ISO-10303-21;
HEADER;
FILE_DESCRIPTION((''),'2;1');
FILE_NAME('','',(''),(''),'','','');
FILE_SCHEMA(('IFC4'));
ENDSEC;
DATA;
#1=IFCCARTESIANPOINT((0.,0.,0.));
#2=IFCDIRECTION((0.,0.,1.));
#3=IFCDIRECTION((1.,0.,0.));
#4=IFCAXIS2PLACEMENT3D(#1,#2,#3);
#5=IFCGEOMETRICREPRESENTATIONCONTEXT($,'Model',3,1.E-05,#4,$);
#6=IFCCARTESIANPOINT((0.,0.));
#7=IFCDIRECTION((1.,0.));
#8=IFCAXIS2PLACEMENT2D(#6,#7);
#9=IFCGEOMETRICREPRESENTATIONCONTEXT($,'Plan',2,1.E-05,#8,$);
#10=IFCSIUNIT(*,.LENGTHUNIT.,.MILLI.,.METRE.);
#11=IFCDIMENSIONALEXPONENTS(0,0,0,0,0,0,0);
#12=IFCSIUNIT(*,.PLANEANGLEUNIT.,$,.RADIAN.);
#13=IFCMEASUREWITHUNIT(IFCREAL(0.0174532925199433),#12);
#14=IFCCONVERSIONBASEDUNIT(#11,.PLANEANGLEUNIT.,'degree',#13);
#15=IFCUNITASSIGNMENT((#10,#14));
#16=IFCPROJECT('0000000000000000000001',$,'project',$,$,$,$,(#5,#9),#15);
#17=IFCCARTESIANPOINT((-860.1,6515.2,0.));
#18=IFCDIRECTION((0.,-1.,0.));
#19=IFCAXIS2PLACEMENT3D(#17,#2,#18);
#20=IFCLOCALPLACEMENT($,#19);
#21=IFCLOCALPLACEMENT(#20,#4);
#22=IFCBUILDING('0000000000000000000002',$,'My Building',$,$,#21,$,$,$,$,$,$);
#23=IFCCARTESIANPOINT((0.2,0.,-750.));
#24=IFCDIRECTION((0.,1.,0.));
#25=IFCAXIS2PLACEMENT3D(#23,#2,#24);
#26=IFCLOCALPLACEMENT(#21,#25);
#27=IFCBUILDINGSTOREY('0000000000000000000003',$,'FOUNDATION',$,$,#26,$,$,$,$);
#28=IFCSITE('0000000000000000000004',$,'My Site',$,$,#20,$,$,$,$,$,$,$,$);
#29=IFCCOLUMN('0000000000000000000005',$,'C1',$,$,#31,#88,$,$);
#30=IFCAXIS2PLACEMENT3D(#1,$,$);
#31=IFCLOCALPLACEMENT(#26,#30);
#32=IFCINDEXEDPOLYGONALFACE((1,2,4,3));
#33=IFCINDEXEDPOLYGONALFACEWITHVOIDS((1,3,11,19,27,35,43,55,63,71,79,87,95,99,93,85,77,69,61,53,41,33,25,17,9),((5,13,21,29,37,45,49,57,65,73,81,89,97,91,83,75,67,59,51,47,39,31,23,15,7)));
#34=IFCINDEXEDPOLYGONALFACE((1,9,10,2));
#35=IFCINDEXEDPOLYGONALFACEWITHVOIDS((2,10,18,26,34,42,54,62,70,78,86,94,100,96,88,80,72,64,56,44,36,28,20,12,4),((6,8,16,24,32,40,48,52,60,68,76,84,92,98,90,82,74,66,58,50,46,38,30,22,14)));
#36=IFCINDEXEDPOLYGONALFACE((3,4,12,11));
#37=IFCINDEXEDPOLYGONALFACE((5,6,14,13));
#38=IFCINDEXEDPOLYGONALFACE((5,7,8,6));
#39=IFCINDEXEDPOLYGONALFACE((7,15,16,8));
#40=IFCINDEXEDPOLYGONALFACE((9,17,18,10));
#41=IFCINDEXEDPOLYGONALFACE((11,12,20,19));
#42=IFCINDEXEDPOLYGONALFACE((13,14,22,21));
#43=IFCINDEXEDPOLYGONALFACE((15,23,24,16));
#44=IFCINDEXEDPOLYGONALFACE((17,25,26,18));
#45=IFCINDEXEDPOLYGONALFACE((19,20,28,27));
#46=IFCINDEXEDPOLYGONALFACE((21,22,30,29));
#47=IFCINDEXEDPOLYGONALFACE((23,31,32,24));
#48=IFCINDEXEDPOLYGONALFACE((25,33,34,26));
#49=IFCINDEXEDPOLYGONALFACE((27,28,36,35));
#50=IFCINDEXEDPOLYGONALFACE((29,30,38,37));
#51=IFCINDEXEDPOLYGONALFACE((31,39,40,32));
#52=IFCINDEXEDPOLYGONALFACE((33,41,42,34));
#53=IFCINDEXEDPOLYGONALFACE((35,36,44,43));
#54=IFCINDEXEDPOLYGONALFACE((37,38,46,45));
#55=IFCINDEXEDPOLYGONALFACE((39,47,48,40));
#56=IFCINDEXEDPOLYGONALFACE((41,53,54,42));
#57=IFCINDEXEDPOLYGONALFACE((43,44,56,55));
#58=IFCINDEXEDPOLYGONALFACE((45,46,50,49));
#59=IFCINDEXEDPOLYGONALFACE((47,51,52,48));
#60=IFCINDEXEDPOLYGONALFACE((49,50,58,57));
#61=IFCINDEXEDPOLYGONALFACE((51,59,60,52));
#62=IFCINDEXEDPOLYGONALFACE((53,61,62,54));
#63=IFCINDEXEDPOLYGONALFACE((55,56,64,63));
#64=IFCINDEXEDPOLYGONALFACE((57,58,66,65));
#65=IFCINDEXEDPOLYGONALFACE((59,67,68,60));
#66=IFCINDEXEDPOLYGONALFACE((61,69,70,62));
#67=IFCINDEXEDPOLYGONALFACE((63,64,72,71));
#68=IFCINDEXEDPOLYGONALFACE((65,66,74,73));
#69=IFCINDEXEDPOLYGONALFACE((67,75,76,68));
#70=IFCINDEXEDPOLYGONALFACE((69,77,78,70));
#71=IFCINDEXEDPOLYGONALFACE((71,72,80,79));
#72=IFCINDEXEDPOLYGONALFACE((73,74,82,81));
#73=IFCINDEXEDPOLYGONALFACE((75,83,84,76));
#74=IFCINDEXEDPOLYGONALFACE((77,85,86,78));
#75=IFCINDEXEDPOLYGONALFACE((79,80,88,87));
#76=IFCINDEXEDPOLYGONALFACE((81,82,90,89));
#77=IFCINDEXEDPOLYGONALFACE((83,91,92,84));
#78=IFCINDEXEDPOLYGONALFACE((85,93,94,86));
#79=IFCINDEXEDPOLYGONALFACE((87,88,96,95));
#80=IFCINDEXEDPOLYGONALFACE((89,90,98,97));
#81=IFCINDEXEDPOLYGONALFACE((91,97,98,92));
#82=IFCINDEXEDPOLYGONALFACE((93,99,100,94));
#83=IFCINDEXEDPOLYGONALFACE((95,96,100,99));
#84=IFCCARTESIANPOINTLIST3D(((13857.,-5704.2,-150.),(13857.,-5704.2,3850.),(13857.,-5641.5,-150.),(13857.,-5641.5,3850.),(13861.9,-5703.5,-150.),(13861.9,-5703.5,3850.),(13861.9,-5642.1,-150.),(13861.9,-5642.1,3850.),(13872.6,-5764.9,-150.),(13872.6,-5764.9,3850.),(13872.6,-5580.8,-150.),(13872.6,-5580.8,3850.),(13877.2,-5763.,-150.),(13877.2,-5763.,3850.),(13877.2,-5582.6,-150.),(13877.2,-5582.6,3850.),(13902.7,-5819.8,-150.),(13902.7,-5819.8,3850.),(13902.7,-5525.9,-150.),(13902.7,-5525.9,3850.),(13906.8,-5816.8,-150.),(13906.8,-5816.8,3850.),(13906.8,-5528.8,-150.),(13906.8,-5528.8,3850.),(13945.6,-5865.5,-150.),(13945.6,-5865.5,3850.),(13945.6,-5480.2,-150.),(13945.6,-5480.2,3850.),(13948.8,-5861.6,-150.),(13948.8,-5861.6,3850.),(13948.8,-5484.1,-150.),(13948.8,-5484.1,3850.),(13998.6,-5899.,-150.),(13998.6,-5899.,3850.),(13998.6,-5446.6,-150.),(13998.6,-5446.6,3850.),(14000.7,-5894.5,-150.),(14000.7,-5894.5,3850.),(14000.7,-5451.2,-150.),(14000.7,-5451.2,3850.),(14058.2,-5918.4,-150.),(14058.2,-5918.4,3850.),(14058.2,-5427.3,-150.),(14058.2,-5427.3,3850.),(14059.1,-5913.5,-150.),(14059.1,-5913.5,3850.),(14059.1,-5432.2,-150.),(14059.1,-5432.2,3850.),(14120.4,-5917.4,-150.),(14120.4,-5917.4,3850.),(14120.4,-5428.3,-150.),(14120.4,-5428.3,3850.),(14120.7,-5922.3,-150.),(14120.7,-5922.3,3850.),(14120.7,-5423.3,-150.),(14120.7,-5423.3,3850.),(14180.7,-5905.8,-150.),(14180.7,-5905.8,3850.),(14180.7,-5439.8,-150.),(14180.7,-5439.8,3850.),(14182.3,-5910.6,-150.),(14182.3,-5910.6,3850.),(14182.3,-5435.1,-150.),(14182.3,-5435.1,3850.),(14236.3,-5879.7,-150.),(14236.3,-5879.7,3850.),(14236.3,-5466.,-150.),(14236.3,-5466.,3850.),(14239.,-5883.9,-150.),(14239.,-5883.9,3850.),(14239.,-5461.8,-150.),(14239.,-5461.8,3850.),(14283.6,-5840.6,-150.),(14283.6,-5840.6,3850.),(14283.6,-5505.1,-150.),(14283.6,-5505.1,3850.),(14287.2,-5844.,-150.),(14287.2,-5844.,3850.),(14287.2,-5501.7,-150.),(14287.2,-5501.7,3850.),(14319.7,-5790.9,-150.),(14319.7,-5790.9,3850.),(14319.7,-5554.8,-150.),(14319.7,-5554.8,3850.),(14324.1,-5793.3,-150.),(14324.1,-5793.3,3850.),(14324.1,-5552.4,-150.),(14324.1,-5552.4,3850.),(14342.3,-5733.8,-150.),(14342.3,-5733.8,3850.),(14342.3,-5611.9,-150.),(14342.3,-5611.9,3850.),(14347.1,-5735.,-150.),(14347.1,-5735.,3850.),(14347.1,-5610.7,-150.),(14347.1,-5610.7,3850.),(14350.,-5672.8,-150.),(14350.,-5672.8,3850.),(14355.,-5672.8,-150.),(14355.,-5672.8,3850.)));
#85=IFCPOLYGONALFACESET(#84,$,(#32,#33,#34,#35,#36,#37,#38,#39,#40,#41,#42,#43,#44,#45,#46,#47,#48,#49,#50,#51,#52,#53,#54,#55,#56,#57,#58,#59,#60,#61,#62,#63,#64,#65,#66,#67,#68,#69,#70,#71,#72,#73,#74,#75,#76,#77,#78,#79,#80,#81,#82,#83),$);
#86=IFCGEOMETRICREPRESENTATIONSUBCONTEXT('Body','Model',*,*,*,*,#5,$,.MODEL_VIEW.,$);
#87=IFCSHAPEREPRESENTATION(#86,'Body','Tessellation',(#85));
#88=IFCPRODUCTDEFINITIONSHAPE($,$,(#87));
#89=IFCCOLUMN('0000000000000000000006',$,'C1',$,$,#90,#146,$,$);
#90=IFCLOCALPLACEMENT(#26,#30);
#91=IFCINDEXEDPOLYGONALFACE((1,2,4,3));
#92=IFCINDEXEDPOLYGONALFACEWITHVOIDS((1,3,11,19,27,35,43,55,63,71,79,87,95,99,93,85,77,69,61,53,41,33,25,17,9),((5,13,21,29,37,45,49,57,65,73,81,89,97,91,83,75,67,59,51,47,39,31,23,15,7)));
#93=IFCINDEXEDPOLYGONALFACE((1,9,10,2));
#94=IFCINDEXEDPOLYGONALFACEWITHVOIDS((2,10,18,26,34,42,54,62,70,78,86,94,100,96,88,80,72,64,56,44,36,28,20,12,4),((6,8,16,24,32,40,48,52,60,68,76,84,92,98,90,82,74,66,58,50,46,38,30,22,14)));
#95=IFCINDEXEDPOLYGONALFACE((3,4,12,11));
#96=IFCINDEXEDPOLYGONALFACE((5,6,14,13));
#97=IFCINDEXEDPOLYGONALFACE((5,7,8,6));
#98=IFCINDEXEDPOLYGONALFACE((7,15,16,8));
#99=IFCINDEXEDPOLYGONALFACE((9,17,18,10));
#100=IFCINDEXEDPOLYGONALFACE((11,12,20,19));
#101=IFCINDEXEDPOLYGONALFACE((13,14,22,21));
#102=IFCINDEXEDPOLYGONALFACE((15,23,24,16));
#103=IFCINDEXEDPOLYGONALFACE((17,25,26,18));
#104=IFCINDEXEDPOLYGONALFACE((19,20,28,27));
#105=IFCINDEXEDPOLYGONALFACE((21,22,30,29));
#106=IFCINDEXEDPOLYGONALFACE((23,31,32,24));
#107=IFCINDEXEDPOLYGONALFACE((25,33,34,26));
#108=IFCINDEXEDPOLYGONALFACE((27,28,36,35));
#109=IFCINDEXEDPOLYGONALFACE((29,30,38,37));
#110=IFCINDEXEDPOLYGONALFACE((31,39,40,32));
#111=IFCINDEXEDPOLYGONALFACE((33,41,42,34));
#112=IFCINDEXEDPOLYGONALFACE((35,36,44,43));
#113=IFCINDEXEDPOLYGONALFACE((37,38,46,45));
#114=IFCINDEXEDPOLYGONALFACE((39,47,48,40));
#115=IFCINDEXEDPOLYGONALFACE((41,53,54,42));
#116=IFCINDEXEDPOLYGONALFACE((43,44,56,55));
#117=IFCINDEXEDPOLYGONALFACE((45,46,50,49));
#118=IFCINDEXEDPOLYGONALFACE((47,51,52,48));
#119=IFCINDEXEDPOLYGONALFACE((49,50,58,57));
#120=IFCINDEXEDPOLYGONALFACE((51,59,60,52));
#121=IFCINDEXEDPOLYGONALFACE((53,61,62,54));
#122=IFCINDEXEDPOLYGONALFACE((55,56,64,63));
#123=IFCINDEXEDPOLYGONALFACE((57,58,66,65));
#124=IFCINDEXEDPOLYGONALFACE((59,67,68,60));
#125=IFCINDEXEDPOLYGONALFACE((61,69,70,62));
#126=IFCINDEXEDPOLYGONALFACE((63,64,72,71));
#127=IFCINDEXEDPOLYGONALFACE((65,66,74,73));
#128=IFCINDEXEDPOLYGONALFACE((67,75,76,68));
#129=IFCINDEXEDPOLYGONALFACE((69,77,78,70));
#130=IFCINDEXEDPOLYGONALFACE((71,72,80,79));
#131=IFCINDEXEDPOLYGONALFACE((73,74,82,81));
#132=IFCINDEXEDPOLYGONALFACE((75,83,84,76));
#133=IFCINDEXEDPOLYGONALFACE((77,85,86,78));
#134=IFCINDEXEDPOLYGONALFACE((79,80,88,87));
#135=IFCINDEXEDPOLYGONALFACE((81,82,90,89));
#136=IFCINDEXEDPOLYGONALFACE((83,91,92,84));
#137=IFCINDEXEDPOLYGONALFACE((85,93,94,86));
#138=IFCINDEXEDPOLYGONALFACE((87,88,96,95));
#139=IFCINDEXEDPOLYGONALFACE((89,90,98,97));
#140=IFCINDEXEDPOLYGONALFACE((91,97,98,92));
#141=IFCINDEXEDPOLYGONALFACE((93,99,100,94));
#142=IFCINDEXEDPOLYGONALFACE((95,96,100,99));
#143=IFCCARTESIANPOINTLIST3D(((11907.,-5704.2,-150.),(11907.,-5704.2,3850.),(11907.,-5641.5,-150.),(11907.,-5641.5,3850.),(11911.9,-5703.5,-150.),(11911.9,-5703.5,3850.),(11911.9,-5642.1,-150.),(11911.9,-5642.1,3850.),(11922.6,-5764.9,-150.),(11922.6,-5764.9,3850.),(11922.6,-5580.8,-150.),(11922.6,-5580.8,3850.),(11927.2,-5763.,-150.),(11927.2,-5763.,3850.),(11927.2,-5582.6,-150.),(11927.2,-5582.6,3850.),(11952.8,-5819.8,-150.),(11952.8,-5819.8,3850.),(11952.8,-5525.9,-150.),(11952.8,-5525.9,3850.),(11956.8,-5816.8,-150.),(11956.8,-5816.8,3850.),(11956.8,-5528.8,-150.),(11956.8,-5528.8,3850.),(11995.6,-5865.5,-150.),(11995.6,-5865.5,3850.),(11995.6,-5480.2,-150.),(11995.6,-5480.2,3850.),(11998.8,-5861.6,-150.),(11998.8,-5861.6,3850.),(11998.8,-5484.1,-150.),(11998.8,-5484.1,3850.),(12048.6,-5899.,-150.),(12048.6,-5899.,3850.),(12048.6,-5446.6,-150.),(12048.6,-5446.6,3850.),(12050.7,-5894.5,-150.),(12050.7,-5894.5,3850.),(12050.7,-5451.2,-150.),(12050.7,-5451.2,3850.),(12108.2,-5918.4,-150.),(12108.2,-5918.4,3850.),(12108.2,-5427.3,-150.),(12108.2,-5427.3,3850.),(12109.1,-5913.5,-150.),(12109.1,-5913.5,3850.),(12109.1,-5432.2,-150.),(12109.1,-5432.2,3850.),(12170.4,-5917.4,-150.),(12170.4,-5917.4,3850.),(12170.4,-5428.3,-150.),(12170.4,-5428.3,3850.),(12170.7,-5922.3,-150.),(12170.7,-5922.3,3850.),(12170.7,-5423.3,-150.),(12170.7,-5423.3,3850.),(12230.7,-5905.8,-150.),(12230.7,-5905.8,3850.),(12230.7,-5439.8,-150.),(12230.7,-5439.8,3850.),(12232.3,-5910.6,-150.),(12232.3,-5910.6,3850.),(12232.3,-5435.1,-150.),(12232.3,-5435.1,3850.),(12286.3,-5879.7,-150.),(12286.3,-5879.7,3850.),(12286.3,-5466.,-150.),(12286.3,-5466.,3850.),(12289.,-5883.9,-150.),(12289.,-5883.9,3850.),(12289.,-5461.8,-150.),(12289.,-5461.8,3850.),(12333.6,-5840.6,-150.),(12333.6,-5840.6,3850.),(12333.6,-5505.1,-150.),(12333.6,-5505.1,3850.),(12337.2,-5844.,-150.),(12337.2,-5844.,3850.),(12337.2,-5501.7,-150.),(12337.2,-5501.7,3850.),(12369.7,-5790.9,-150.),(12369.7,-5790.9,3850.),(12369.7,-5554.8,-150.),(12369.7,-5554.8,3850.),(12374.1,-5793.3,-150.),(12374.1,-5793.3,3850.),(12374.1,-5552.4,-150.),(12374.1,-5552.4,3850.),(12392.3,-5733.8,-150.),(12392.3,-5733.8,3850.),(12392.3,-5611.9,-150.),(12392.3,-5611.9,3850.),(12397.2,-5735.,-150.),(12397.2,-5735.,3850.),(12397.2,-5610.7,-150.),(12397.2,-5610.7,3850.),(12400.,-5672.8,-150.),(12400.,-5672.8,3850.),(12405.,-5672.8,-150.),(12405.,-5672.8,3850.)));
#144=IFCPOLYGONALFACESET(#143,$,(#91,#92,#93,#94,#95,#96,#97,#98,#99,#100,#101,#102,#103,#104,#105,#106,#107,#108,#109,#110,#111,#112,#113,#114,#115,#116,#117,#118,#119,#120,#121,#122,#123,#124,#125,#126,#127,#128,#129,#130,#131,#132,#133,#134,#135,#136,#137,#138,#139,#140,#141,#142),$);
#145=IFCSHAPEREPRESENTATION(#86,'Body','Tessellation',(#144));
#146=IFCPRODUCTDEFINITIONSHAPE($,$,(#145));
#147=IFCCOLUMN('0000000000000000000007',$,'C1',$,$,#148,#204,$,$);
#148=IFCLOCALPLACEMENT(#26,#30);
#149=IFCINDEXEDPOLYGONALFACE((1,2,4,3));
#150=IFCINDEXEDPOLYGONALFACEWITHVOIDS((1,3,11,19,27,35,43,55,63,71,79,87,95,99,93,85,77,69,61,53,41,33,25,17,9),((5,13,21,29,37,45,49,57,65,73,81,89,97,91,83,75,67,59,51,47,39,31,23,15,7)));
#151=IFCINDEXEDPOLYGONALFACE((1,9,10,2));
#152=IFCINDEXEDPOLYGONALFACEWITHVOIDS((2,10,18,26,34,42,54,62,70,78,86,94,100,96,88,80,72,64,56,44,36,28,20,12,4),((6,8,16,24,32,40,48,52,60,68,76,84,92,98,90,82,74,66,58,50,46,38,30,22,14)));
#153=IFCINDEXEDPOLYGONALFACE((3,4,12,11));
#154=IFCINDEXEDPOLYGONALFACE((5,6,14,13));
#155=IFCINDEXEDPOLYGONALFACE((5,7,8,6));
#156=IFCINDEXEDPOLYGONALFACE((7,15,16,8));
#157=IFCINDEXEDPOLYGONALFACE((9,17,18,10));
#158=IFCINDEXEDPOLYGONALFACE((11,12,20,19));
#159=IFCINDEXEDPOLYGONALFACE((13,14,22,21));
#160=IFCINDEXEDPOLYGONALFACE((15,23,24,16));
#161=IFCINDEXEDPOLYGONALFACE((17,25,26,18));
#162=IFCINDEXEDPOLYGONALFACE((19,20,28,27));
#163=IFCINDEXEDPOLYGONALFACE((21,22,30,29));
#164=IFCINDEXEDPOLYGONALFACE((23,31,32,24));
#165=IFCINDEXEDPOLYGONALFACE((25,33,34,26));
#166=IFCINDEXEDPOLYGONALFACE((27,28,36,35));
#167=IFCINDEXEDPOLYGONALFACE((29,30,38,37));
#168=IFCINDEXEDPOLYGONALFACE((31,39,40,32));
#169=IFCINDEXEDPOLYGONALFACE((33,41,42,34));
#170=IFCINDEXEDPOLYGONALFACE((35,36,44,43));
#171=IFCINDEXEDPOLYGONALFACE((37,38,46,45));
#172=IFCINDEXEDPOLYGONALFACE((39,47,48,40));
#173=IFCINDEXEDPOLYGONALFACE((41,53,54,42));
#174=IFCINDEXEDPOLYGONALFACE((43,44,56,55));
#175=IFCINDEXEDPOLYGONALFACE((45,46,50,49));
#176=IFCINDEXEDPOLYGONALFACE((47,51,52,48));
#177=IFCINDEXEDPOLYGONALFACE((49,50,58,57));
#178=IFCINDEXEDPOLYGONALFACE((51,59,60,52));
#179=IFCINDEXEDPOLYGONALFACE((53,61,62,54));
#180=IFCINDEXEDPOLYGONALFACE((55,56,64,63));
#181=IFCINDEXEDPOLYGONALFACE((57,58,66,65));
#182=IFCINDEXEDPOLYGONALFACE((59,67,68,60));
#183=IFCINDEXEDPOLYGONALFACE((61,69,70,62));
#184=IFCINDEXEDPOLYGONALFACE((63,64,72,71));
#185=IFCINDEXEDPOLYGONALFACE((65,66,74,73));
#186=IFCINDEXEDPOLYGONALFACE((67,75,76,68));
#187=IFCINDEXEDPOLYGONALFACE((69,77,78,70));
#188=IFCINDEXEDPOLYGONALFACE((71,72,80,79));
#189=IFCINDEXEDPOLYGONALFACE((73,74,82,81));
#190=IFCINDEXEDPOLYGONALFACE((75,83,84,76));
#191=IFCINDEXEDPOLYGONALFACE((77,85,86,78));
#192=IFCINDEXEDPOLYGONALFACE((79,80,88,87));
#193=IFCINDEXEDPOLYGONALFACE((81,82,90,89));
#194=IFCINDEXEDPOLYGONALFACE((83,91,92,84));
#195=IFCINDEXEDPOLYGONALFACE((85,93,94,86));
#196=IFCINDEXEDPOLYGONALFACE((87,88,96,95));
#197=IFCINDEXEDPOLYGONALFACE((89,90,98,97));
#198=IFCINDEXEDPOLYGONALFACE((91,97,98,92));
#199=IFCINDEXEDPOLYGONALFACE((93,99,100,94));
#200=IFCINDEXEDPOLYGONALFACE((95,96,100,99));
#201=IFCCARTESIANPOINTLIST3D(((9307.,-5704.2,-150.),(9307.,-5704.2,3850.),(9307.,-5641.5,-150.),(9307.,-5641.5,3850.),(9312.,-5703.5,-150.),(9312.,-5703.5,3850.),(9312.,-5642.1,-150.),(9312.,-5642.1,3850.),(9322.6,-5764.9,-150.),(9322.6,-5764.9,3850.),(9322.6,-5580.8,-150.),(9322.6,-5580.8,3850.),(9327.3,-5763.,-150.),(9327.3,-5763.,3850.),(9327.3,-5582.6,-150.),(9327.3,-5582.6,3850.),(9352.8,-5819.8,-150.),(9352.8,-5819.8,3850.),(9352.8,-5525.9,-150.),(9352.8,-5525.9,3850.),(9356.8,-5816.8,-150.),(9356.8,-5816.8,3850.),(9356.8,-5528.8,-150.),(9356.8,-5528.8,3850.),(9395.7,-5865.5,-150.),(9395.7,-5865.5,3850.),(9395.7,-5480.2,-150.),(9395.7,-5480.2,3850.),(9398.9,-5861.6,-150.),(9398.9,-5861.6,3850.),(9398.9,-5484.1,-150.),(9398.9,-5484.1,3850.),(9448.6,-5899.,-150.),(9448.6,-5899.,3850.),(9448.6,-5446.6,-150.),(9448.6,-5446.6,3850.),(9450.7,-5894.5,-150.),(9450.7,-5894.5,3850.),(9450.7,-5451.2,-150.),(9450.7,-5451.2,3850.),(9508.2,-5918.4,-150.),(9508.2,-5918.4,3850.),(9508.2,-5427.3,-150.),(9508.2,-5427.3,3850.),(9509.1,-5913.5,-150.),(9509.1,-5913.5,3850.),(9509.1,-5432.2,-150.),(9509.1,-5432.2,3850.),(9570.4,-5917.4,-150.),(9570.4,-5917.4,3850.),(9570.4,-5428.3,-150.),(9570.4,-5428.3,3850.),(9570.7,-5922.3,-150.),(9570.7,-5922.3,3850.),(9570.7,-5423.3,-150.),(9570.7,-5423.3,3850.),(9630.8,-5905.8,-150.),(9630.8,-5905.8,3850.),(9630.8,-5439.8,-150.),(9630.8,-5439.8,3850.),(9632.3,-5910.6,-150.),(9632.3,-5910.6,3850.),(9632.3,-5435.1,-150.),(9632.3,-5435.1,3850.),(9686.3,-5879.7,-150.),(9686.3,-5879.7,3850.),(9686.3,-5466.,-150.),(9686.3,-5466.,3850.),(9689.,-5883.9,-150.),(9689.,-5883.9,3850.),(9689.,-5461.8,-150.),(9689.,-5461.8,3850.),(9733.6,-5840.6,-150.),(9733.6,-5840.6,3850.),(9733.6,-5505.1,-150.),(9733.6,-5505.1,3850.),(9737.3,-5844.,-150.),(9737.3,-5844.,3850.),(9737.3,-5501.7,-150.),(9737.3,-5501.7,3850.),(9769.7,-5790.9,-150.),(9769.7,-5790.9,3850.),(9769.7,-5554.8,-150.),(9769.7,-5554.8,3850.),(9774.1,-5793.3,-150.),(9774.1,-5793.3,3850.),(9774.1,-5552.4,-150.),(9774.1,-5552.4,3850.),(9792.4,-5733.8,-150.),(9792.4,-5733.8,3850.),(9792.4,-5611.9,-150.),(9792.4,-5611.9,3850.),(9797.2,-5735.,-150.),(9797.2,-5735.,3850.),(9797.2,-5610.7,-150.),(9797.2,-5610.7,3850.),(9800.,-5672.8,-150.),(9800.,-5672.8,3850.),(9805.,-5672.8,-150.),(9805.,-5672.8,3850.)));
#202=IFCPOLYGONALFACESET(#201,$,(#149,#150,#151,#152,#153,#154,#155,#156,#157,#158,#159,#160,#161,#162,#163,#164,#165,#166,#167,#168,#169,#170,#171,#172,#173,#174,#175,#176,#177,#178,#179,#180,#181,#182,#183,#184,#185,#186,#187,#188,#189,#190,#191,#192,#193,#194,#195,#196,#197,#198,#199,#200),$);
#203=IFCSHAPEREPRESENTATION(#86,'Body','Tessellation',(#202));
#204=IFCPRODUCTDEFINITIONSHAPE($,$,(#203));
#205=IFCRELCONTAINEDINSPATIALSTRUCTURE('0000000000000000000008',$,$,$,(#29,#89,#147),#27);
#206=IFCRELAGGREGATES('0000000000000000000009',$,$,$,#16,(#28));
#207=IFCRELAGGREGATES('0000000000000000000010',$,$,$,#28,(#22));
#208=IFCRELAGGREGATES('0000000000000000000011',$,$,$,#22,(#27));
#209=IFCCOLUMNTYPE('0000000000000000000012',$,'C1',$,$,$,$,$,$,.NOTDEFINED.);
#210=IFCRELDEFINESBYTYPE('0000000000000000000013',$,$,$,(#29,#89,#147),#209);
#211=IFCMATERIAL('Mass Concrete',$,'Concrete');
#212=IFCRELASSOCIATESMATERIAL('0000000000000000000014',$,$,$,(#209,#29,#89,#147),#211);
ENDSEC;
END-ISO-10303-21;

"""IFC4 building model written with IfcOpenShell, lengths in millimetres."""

from ifc_helpers import new_model, entity, si_unit, converted_unit, frame, origin_with_axes, origin_2d_with_axis, place, context, subcontext, project, spatial, rectangle, hollow_circle, extrude, material, material_profile, profile_set, profile_usage, type_object, element, save


model = new_model("IFC4")

# Units and contexts
model_context = context("Model", 3, precision=1e-05, world=origin_with_axes())
plan_context = context("Plan", 2, precision=1e-05, world=origin_2d_with_axis())
body_context = subcontext(model_context, "Body", "Model", "MODEL_VIEW")
ifc_project = project(units=[si_unit("LENGTHUNIT", "METRE", prefix="MILLI"), converted_unit("PLANEANGLEUNIT", "degree", entity("IfcReal", 0.0174532925199433), si_unit("PLANEANGLEUNIT", "RADIAN"), dimensions=[0, 0, 0, 0, 0, 0, 0])], contexts=[model_context, plan_context])

# Site, building, storey
site_placement = place(None, frame((-860.1, 6515.2, 0.0), z_axis=(0.0, 0.0, 1.0), x_axis=(0.0, -1.0, 0.0)))
site = spatial("IfcSite", under=ifc_project, at=site_placement, Name="My Site")
building_placement = place(site_placement, frame((0.0, 0.0, 0.0), z_axis=(0.0, 0.0, 1.0), x_axis=(1.0, 0.0, 0.0)))
building = spatial("IfcBuilding", under=site, at=building_placement, Name="My Building")
storey_placement = place(building_placement, frame((0.2, 0.0, -750.0), z_axis=(0.0, 0.0, 1.0), x_axis=(0.0, 1.0, 0.0)))
storey = spatial("IfcBuildingStorey", under=building, at=storey_placement, Name="FOUNDATION")

# Shared definitions
ifc_material_1 = material(Name="Mass Concrete", Category="Concrete")

# Columns
ifc_material_profile = material_profile(ifc_material_1, rectangle(XDim=150.0, YDim=150.0), Name="Square Column", Category="Structure", Priority=1)
ifc_profile_set = profile_set([ifc_material_profile], Name="RC_COL_150x150")
column_type = type_object("IfcColumnType", Name="C1", PredefinedType="NOTDEFINED", material=ifc_profile_set)
ifc_profile_usage_1 = profile_usage(ifc_profile_set, cardinal=5)
column_1_placement = place(storey_placement, frame((14105.0, -5672.8, -150.0), z_axis=(0.0, 0.0, 1.0), x_axis=(1.0, 0.0, 0.0)))
element("IfcColumn", 1, at=column_1_placement, inside=storey, type_object=column_type, material=ifc_profile_usage_1, Name="C1", context=body_context, shape_type="SweptSolid", body=[
    extrude(hollow_circle(Radius=250.0, WallThickness=5.0), origin_with_axes(), (0.0, 0.0, 1.0), 4000.0),
])
ifc_profile_usage_2 = profile_usage(ifc_profile_set, cardinal=5)
column_2_placement = place(storey_placement, frame((12155.0, -5672.8, -150.0), z_axis=(0.0, 0.0, 1.0), x_axis=(1.0, 0.0, 0.0)))
element("IfcColumn", 2, at=column_2_placement, inside=storey, type_object=column_type, material=ifc_profile_usage_2, Name="C1", context=body_context, shape_type="SweptSolid", body=[
    extrude(hollow_circle(Radius=250.0, WallThickness=5.0), origin_with_axes(), (0.0, 0.0, 1.0), 4000.0),
])
ifc_profile_usage_3 = profile_usage(ifc_profile_set, cardinal=5)
column_3_placement = place(storey_placement, frame((9555.0, -5672.8, -150.0), z_axis=(0.0, 0.0, 1.0), x_axis=(1.0, 0.0, 0.0)))
element("IfcColumn", 3, at=column_3_placement, inside=storey, type_object=column_type, material=ifc_profile_usage_3, Name="C1", context=body_context, shape_type="SweptSolid", body=[
    extrude(hollow_circle(Radius=250.0, WallThickness=5.0), origin_with_axes(), (0.0, 0.0, 1.0), 4000.0),
])

save(model, "model.ifc")
